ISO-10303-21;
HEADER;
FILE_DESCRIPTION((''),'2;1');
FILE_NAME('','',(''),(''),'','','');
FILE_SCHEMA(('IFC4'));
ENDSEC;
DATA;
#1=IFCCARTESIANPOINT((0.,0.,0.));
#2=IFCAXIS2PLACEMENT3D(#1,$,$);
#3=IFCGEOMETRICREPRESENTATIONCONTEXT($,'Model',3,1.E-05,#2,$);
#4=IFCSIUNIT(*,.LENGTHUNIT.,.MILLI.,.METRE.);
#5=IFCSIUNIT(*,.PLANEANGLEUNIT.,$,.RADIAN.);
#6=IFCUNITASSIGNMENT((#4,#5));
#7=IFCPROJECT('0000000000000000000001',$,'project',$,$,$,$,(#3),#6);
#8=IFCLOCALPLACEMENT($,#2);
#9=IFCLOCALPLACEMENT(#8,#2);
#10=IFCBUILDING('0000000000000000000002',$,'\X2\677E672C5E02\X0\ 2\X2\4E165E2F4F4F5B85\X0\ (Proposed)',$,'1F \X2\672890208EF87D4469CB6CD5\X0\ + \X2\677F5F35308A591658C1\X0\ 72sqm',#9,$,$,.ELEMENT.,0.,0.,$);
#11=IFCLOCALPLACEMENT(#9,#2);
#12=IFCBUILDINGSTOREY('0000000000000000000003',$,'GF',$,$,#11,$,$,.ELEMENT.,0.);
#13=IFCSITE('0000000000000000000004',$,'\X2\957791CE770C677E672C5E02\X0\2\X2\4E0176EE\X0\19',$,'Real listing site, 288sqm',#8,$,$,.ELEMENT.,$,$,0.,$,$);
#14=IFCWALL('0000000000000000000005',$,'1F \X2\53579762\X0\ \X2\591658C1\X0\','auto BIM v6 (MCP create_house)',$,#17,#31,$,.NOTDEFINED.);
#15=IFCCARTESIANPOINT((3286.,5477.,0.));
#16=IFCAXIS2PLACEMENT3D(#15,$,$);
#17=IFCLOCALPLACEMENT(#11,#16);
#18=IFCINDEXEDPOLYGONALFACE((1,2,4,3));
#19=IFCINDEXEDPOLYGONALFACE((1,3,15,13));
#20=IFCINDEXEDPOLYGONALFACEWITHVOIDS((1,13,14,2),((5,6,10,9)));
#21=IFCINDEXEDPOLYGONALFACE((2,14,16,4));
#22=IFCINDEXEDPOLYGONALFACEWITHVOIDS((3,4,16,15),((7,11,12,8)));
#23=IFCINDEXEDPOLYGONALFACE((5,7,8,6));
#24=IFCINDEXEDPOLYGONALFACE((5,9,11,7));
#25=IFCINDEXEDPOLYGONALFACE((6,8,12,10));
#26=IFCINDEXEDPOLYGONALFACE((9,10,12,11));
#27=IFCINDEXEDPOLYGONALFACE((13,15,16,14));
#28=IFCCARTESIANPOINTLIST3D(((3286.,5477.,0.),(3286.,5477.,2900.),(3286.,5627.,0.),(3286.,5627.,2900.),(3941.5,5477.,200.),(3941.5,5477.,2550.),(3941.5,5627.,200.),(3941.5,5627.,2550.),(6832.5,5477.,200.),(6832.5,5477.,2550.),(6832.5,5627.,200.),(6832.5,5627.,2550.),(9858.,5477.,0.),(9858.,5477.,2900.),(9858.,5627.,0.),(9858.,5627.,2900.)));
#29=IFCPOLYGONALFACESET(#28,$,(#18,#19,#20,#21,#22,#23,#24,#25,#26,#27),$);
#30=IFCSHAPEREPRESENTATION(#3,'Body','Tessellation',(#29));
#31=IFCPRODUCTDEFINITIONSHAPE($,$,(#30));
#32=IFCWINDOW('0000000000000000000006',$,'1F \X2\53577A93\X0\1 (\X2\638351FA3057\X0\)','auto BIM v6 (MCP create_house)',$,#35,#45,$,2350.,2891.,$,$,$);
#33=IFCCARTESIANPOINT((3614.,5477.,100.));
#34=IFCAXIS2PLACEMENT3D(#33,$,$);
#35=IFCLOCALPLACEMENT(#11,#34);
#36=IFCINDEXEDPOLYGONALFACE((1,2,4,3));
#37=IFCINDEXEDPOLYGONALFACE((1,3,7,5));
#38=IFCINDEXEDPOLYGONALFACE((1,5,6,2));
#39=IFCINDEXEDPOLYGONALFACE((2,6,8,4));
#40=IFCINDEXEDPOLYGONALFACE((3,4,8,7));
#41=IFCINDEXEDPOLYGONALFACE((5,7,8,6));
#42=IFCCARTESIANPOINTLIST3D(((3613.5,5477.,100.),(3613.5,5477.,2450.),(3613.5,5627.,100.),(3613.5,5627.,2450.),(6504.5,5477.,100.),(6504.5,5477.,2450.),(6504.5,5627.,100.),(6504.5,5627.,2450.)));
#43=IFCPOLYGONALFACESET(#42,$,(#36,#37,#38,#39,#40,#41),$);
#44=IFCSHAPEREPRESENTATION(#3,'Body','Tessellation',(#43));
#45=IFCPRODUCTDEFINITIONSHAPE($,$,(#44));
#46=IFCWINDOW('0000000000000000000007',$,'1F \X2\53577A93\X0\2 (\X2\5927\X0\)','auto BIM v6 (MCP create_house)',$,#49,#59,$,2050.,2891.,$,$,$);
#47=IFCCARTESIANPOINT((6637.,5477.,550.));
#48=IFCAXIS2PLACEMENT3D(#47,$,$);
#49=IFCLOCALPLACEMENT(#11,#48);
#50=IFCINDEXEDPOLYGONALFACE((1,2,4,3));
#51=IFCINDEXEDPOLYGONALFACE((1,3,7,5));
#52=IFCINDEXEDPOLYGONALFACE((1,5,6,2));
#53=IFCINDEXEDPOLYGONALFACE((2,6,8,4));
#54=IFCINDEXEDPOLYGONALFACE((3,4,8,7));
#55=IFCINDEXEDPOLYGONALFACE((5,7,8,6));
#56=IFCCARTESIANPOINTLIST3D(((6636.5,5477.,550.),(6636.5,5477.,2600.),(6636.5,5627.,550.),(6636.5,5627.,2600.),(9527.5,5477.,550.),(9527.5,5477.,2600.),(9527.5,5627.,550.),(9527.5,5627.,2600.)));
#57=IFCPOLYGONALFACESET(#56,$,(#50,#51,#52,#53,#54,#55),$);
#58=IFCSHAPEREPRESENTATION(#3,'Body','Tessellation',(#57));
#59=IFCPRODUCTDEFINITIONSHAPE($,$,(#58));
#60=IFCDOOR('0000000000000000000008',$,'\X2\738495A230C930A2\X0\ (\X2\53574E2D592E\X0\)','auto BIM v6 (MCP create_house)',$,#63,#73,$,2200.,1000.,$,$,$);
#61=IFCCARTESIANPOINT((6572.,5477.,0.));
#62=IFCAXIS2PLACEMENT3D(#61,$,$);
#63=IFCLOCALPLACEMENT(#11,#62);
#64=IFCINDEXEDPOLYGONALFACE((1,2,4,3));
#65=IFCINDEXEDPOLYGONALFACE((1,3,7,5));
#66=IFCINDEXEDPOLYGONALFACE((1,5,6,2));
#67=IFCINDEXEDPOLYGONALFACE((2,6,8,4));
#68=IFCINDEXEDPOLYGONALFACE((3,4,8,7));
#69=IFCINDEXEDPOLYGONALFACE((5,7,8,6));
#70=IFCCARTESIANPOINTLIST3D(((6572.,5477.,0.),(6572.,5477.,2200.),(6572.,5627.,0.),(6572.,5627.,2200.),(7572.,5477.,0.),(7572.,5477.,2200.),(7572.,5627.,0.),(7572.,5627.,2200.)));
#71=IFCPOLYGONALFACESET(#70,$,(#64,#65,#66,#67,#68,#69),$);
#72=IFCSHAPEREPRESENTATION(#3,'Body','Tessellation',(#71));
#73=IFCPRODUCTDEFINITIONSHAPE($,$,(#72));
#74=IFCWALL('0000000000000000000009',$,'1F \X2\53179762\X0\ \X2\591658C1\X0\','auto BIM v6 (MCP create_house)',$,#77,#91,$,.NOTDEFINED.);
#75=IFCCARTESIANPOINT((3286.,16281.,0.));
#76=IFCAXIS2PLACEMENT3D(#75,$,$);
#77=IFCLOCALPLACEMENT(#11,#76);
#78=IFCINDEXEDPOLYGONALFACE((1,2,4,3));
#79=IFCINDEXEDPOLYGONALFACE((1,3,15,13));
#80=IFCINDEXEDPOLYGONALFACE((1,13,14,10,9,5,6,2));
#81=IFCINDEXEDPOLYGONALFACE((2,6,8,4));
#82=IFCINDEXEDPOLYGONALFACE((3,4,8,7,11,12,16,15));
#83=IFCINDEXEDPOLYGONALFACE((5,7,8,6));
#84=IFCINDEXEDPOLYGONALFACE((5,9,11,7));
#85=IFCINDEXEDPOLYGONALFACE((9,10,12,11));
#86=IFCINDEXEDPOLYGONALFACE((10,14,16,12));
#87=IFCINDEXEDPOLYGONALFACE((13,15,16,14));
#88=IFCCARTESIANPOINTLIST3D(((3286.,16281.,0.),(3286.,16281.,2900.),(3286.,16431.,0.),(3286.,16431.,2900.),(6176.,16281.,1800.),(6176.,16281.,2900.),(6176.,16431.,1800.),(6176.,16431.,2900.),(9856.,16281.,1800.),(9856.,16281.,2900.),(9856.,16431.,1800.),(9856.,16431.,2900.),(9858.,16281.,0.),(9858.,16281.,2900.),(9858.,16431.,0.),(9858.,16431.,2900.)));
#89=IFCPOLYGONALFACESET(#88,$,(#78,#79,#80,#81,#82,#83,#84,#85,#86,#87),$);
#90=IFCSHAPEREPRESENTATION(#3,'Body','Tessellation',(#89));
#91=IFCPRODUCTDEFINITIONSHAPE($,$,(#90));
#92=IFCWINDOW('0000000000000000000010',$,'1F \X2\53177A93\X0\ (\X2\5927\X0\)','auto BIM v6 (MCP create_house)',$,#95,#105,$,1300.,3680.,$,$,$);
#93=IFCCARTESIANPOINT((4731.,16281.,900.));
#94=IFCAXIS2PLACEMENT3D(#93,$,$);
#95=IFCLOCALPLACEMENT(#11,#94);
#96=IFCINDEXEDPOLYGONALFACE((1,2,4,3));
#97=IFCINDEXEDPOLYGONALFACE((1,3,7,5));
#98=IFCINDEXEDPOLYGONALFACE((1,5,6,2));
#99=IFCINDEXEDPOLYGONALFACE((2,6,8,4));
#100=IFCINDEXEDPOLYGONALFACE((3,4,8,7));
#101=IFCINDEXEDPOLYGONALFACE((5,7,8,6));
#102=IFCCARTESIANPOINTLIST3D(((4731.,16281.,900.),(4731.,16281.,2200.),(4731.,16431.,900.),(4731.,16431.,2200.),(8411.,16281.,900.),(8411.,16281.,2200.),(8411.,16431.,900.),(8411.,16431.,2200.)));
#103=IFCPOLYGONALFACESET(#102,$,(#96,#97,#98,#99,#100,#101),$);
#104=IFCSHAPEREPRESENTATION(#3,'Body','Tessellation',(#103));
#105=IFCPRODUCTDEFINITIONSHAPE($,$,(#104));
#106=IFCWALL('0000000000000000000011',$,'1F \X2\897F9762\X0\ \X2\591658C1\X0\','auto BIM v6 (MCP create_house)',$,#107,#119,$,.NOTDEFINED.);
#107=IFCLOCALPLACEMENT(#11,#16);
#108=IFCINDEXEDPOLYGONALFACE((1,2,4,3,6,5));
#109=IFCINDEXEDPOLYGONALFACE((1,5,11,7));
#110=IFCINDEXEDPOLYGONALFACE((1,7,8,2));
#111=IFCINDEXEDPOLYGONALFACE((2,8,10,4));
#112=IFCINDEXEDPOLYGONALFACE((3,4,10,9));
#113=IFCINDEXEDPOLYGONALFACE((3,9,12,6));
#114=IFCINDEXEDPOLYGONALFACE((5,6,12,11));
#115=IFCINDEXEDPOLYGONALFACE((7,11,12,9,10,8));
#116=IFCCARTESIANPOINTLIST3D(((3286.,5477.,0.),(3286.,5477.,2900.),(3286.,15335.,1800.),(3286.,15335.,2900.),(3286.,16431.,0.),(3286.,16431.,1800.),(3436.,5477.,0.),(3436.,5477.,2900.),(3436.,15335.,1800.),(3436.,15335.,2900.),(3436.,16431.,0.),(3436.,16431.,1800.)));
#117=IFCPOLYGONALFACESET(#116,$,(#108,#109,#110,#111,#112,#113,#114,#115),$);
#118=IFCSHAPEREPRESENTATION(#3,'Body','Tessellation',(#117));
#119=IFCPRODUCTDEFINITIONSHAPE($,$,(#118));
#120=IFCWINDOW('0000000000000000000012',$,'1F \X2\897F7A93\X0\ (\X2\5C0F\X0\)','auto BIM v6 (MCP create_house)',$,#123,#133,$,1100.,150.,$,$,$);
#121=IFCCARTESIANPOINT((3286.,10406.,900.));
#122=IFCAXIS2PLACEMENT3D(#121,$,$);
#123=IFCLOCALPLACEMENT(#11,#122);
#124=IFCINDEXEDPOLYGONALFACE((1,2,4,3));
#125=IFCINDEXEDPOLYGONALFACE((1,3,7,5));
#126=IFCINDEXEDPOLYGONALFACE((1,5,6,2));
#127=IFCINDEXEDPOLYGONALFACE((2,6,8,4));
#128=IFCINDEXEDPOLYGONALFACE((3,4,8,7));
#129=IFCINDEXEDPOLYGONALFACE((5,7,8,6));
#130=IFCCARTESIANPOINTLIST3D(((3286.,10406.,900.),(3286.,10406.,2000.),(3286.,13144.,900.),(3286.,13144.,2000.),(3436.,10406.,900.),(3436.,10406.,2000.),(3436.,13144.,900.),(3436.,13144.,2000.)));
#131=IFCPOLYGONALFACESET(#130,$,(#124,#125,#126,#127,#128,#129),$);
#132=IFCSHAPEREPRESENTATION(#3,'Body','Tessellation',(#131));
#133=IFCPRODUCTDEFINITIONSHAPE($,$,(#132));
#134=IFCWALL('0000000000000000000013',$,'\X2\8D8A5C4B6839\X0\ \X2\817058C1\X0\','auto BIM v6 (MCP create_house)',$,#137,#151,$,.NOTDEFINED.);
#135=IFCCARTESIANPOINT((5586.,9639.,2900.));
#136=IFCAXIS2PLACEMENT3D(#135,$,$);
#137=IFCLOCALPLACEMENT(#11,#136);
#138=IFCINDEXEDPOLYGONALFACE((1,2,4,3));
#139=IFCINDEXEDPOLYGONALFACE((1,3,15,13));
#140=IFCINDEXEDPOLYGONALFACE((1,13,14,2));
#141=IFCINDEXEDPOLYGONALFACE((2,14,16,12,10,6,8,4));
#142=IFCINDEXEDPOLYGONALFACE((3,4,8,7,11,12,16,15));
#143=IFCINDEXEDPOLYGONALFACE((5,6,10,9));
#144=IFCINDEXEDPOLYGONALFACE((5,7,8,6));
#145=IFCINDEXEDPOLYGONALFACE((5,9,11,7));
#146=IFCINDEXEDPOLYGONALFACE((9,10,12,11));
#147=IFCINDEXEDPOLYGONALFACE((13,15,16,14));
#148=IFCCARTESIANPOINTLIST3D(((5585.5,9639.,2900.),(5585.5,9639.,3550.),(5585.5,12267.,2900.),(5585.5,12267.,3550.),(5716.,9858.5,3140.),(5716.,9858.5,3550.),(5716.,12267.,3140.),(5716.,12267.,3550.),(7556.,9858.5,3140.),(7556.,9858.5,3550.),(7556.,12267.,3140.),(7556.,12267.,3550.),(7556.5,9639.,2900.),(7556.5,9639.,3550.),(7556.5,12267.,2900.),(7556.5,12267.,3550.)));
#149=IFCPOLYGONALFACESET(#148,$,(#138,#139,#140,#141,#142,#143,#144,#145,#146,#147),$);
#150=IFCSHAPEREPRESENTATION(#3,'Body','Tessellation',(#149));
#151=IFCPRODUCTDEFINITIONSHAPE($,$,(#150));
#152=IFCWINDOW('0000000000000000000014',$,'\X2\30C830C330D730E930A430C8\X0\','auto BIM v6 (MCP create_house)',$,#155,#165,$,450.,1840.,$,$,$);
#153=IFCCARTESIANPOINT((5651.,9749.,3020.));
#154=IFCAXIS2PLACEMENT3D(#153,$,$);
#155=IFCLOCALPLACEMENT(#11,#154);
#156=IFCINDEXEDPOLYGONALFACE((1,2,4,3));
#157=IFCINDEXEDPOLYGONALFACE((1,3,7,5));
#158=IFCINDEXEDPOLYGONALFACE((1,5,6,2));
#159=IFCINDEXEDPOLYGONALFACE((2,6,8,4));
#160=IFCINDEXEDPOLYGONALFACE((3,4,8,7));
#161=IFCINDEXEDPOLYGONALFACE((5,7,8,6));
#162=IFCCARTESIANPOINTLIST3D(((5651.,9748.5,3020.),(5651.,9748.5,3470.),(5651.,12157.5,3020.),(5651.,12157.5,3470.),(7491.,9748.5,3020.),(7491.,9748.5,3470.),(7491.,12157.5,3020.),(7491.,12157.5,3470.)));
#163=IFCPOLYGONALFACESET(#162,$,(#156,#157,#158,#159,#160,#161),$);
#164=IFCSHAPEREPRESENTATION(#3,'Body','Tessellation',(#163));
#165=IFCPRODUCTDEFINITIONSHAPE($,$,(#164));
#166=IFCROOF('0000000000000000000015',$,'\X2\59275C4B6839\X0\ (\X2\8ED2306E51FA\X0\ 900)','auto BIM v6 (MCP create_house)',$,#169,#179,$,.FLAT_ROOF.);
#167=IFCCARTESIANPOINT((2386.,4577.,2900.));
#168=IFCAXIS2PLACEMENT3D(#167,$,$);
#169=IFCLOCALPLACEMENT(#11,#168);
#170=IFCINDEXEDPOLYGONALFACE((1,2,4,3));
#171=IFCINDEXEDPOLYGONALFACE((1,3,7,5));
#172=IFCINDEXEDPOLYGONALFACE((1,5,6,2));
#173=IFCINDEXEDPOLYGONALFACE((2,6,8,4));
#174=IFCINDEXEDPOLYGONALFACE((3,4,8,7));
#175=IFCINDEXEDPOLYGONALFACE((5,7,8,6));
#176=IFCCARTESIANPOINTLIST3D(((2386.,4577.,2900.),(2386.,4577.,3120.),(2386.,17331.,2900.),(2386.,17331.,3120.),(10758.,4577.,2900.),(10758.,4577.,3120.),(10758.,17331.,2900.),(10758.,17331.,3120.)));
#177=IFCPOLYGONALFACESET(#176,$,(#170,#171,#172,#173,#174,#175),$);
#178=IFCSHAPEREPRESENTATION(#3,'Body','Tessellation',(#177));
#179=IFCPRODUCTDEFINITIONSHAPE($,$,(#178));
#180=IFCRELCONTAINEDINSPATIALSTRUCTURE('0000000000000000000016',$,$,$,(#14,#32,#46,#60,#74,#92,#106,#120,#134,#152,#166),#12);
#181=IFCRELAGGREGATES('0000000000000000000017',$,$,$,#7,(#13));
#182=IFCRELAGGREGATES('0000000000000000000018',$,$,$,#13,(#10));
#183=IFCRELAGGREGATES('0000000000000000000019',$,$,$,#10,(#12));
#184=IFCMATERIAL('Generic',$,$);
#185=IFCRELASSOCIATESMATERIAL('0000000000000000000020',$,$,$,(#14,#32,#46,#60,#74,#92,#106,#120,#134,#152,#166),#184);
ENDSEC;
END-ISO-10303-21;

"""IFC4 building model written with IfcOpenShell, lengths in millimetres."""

from ifc_helpers import new_model, si_unit, frame, frame_2d, origin, place, context, project, spatial, rectangle, extrude, material, element, fill, save


model = new_model("IFC4")

# Units and contexts
model_context = context("Model", 3, precision=1e-05, world=origin())
ifc_project = project(units=[si_unit("LENGTHUNIT", "METRE", prefix="MILLI"), si_unit("PLANEANGLEUNIT", "RADIAN")], contexts=[model_context])

# Site, building, storey
site_placement = place(None, origin())
site = spatial("IfcSite", under=ifc_project, at=site_placement, Name="長野県松本市2丁目19", ObjectType="Real listing site, 288sqm", CompositionType="ELEMENT", RefElevation=0.0)
building_placement = place(site_placement, origin())
building = spatial("IfcBuilding", under=site, at=building_placement, Name="松本市 2世帯住宅 (Proposed)", ObjectType="1F 木造軸組構法 + 板張り外壁 72sqm", CompositionType="ELEMENT", ElevationOfRefHeight=0.0, ElevationOfTerrain=0.0)
storey_placement = place(building_placement, origin())
storey = spatial("IfcBuildingStorey", under=building, at=storey_placement, Name="GF", CompositionType="ELEMENT", Elevation=0.0)

# Shared definitions
ifc_material = material(Name="Generic")

# Wall, openings, windows, door
wall_1_placement = place(storey_placement, frame((3286.0, 5477.0, 0.0)))
wall_1 = element("IfcWall", 1, at=wall_1_placement, inside=storey, material=ifc_material, Name="1F 南面 外壁", Description="auto BIM v6 (MCP create_house)", PredefinedType="NOTDEFINED", context=model_context, shape_type="SweptSolid", body=[
    extrude(rectangle(XDim=6572.0, YDim=150.0, at=frame_2d((3286.0, 75.0))), frame((3286.0, 5477.0, 0.0)), (0.0, 0.0, 1.0), 2900.0),
])
opening_1_placement = place(storey_placement, frame((3614.0, 5477.0, 100.0)))
opening_1 = element("IfcOpeningElement", 2, at=opening_1_placement, cuts=wall_1, PredefinedType="NOTDEFINED", context=model_context, shape_type="SweptSolid", body=[
    extrude(rectangle(XDim=2891.0, YDim=150.0, at=frame_2d((1445.0, 75.0))), frame((3614.0, 5477.0, 100.0)), (0.0, 0.0, 1.0), 2350.0),
])
opening_2_placement = place(storey_placement, frame((6637.0, 5477.0, 550.0)))
opening_2 = element("IfcOpeningElement", 3, at=opening_2_placement, cuts=wall_1, PredefinedType="NOTDEFINED", context=model_context, shape_type="SweptSolid", body=[
    extrude(rectangle(XDim=2891.0, YDim=150.0, at=frame_2d((1445.0, 75.0))), frame((6637.0, 5477.0, 550.0)), (0.0, 0.0, 1.0), 2050.0),
])
opening_3_placement = place(storey_placement, frame((6572.0, 5477.0, 0.0)))
opening_3 = element("IfcOpeningElement", 4, at=opening_3_placement, cuts=wall_1, PredefinedType="NOTDEFINED", context=model_context, shape_type="SweptSolid", body=[
    extrude(rectangle(XDim=1000.0, YDim=150.0, at=frame_2d((500.0, 75.0))), frame((6572.0, 5477.0, 0.0)), (0.0, 0.0, 1.0), 2200.0),
])
window_1_placement = place(storey_placement, frame((3614.0, 5477.0, 100.0)))
window_1 = element("IfcWindow", 5, at=window_1_placement, inside=storey, material=ifc_material, Name="1F 南窓1 (掃出し)", Description="auto BIM v6 (MCP create_house)", OverallHeight=2350.0, OverallWidth=2891.0, context=model_context, shape_type="SweptSolid", body=[
    extrude(rectangle(XDim=2891.0, YDim=150.0, at=frame_2d((1445.0, 75.0))), frame((3614.0, 5477.0, 100.0)), (0.0, 0.0, 1.0), 2350.0),
])
fill(opening_1, window_1)
window_2_placement = place(storey_placement, frame((6637.0, 5477.0, 550.0)))
window_2 = element("IfcWindow", 6, at=window_2_placement, inside=storey, material=ifc_material, Name="1F 南窓2 (大)", Description="auto BIM v6 (MCP create_house)", OverallHeight=2050.0, OverallWidth=2891.0, context=model_context, shape_type="SweptSolid", body=[
    extrude(rectangle(XDim=2891.0, YDim=150.0, at=frame_2d((1445.0, 75.0))), frame((6637.0, 5477.0, 550.0)), (0.0, 0.0, 1.0), 2050.0),
])
fill(opening_2, window_2)
door_placement = place(storey_placement, frame((6572.0, 5477.0, 0.0)))
door = element("IfcDoor", 7, at=door_placement, inside=storey, material=ifc_material, Name="玄関ドア (南中央)", Description="auto BIM v6 (MCP create_house)", OverallHeight=2200.0, OverallWidth=1000.0, context=model_context, shape_type="SweptSolid", body=[
    extrude(rectangle(XDim=1000.0, YDim=150.0, at=frame_2d((500.0, 75.0))), frame((6572.0, 5477.0, 0.0)), (0.0, 0.0, 1.0), 2200.0),
])
fill(opening_3, door)

# Walls, openings, windows
wall_2_placement = place(storey_placement, frame((3286.0, 16281.0, 0.0)))
wall_2 = element("IfcWall", 8, at=wall_2_placement, inside=storey, material=ifc_material, Name="1F 北面 外壁", Description="auto BIM v6 (MCP create_house)", PredefinedType="NOTDEFINED", context=model_context, shape_type="SweptSolid", body=[
    extrude(rectangle(XDim=6572.0, YDim=150.0, at=frame_2d((3286.0, 75.0))), frame((3286.0, 16281.0, 0.0)), (0.0, 0.0, 1.0), 2900.0),
])
opening_4_placement = place(storey_placement, frame((4731.0, 16281.0, 900.0)))
opening_4 = element("IfcOpeningElement", 9, at=opening_4_placement, cuts=wall_2, PredefinedType="NOTDEFINED", context=model_context, shape_type="SweptSolid", body=[
    extrude(rectangle(XDim=3680.0, YDim=150.0, at=frame_2d((1840.0, 75.0))), frame((4731.0, 16281.0, 900.0)), (0.0, 0.0, 1.0), 1300.0),
])
window_3_placement = place(storey_placement, frame((4731.0, 16281.0, 900.0)))
window_3 = element("IfcWindow", 10, at=window_3_placement, inside=storey, material=ifc_material, Name="1F 北窓 (大)", Description="auto BIM v6 (MCP create_house)", OverallHeight=1300.0, OverallWidth=3680.0, context=model_context, shape_type="SweptSolid", body=[
    extrude(rectangle(XDim=3680.0, YDim=150.0, at=frame_2d((1840.0, 75.0))), frame((4731.0, 16281.0, 900.0)), (0.0, 0.0, 1.0), 1300.0),
])
fill(opening_4, window_3)
wall_3_placement = place(storey_placement, frame((3286.0, 5477.0, 0.0)))
wall_3 = element("IfcWall", 11, at=wall_3_placement, inside=storey, material=ifc_material, Name="1F 西面 外壁", Description="auto BIM v6 (MCP create_house)", PredefinedType="NOTDEFINED", context=model_context, shape_type="SweptSolid", body=[
    extrude(rectangle(XDim=150.0, YDim=10954.0, at=frame_2d((75.0, 5477.0))), frame((3286.0, 5477.0, 0.0)), (0.0, 0.0, 1.0), 2900.0),
])
opening_5_placement = place(storey_placement, frame((3286.0, 10406.0, 900.0)))
opening_5 = element("IfcOpeningElement", 12, at=opening_5_placement, cuts=wall_3, PredefinedType="NOTDEFINED", context=model_context, shape_type="SweptSolid", body=[
    extrude(rectangle(XDim=150.0, YDim=2738.0, at=frame_2d((75.0, 1369.0))), frame((3286.0, 10406.0, 900.0)), (0.0, 0.0, 1.0), 1100.0),
])
window_4_placement = place(storey_placement, frame((3286.0, 10406.0, 900.0)))
window_4 = element("IfcWindow", 13, at=window_4_placement, inside=storey, material=ifc_material, Name="1F 西窓 (小)", Description="auto BIM v6 (MCP create_house)", OverallHeight=1100.0, OverallWidth=150.0, context=model_context, shape_type="SweptSolid", body=[
    extrude(rectangle(XDim=150.0, YDim=2738.0, at=frame_2d((75.0, 1369.0))), frame((3286.0, 10406.0, 900.0)), (0.0, 0.0, 1.0), 1100.0),
])
fill(opening_5, window_4)

# Wall, opening, window
wall_4_placement = place(storey_placement, frame((5586.0, 9639.0, 2900.0)))
wall_4 = element("IfcWall", 14, at=wall_4_placement, inside=storey, material=ifc_material, Name="越屋根 腰壁", Description="auto BIM v6 (MCP create_house)", PredefinedType="NOTDEFINED", context=model_context, shape_type="SweptSolid", body=[
    extrude(rectangle(XDim=1971.0, YDim=2628.0, at=frame_2d((985.0, 1314.0))), frame((5586.0, 9639.0, 2900.0)), (0.0, 0.0, 1.0), 650.0),
])
opening_6_placement = place(storey_placement, frame((5651.0, 9749.0, 3020.0)))
opening_6 = element("IfcOpeningElement", 15, at=opening_6_placement, cuts=wall_4, PredefinedType="NOTDEFINED", context=model_context, shape_type="SweptSolid", body=[
    extrude(rectangle(XDim=1840.0, YDim=2409.0, at=frame_2d((920.0, 1204.0))), frame((5651.0, 9749.0, 3020.0)), (0.0, 0.0, 1.0), 450.0),
])
window_5_placement = place(storey_placement, frame((5651.0, 9749.0, 3020.0)))
window_5 = element("IfcWindow", 16, at=window_5_placement, inside=storey, material=ifc_material, Name="トップライト", Description="auto BIM v6 (MCP create_house)", OverallHeight=450.0, OverallWidth=1840.0, context=model_context, shape_type="SweptSolid", body=[
    extrude(rectangle(XDim=1840.0, YDim=2409.0, at=frame_2d((920.0, 1204.0))), frame((5651.0, 9749.0, 3020.0)), (0.0, 0.0, 1.0), 450.0),
])
fill(opening_6, window_5)

# Roof
roof_1_placement = place(storey_placement, frame((2386.0, 4577.0, 2900.0)))
element("IfcRoof", 17, at=roof_1_placement, inside=storey, material=ifc_material, Name="大屋根 (軒の出 900)", Description="auto BIM v6 (MCP create_house)", PredefinedType="FLAT_ROOF", context=model_context, shape_type="SweptSolid", body=[
    extrude(rectangle(XDim=8372.0, YDim=12754.0, at=frame_2d((4186.0, 6377.0))), frame((2386.0, 4577.0, 2900.0)), (0.0, 0.0, 1.0), 220.0),
])

save(model, "model.ifc")
